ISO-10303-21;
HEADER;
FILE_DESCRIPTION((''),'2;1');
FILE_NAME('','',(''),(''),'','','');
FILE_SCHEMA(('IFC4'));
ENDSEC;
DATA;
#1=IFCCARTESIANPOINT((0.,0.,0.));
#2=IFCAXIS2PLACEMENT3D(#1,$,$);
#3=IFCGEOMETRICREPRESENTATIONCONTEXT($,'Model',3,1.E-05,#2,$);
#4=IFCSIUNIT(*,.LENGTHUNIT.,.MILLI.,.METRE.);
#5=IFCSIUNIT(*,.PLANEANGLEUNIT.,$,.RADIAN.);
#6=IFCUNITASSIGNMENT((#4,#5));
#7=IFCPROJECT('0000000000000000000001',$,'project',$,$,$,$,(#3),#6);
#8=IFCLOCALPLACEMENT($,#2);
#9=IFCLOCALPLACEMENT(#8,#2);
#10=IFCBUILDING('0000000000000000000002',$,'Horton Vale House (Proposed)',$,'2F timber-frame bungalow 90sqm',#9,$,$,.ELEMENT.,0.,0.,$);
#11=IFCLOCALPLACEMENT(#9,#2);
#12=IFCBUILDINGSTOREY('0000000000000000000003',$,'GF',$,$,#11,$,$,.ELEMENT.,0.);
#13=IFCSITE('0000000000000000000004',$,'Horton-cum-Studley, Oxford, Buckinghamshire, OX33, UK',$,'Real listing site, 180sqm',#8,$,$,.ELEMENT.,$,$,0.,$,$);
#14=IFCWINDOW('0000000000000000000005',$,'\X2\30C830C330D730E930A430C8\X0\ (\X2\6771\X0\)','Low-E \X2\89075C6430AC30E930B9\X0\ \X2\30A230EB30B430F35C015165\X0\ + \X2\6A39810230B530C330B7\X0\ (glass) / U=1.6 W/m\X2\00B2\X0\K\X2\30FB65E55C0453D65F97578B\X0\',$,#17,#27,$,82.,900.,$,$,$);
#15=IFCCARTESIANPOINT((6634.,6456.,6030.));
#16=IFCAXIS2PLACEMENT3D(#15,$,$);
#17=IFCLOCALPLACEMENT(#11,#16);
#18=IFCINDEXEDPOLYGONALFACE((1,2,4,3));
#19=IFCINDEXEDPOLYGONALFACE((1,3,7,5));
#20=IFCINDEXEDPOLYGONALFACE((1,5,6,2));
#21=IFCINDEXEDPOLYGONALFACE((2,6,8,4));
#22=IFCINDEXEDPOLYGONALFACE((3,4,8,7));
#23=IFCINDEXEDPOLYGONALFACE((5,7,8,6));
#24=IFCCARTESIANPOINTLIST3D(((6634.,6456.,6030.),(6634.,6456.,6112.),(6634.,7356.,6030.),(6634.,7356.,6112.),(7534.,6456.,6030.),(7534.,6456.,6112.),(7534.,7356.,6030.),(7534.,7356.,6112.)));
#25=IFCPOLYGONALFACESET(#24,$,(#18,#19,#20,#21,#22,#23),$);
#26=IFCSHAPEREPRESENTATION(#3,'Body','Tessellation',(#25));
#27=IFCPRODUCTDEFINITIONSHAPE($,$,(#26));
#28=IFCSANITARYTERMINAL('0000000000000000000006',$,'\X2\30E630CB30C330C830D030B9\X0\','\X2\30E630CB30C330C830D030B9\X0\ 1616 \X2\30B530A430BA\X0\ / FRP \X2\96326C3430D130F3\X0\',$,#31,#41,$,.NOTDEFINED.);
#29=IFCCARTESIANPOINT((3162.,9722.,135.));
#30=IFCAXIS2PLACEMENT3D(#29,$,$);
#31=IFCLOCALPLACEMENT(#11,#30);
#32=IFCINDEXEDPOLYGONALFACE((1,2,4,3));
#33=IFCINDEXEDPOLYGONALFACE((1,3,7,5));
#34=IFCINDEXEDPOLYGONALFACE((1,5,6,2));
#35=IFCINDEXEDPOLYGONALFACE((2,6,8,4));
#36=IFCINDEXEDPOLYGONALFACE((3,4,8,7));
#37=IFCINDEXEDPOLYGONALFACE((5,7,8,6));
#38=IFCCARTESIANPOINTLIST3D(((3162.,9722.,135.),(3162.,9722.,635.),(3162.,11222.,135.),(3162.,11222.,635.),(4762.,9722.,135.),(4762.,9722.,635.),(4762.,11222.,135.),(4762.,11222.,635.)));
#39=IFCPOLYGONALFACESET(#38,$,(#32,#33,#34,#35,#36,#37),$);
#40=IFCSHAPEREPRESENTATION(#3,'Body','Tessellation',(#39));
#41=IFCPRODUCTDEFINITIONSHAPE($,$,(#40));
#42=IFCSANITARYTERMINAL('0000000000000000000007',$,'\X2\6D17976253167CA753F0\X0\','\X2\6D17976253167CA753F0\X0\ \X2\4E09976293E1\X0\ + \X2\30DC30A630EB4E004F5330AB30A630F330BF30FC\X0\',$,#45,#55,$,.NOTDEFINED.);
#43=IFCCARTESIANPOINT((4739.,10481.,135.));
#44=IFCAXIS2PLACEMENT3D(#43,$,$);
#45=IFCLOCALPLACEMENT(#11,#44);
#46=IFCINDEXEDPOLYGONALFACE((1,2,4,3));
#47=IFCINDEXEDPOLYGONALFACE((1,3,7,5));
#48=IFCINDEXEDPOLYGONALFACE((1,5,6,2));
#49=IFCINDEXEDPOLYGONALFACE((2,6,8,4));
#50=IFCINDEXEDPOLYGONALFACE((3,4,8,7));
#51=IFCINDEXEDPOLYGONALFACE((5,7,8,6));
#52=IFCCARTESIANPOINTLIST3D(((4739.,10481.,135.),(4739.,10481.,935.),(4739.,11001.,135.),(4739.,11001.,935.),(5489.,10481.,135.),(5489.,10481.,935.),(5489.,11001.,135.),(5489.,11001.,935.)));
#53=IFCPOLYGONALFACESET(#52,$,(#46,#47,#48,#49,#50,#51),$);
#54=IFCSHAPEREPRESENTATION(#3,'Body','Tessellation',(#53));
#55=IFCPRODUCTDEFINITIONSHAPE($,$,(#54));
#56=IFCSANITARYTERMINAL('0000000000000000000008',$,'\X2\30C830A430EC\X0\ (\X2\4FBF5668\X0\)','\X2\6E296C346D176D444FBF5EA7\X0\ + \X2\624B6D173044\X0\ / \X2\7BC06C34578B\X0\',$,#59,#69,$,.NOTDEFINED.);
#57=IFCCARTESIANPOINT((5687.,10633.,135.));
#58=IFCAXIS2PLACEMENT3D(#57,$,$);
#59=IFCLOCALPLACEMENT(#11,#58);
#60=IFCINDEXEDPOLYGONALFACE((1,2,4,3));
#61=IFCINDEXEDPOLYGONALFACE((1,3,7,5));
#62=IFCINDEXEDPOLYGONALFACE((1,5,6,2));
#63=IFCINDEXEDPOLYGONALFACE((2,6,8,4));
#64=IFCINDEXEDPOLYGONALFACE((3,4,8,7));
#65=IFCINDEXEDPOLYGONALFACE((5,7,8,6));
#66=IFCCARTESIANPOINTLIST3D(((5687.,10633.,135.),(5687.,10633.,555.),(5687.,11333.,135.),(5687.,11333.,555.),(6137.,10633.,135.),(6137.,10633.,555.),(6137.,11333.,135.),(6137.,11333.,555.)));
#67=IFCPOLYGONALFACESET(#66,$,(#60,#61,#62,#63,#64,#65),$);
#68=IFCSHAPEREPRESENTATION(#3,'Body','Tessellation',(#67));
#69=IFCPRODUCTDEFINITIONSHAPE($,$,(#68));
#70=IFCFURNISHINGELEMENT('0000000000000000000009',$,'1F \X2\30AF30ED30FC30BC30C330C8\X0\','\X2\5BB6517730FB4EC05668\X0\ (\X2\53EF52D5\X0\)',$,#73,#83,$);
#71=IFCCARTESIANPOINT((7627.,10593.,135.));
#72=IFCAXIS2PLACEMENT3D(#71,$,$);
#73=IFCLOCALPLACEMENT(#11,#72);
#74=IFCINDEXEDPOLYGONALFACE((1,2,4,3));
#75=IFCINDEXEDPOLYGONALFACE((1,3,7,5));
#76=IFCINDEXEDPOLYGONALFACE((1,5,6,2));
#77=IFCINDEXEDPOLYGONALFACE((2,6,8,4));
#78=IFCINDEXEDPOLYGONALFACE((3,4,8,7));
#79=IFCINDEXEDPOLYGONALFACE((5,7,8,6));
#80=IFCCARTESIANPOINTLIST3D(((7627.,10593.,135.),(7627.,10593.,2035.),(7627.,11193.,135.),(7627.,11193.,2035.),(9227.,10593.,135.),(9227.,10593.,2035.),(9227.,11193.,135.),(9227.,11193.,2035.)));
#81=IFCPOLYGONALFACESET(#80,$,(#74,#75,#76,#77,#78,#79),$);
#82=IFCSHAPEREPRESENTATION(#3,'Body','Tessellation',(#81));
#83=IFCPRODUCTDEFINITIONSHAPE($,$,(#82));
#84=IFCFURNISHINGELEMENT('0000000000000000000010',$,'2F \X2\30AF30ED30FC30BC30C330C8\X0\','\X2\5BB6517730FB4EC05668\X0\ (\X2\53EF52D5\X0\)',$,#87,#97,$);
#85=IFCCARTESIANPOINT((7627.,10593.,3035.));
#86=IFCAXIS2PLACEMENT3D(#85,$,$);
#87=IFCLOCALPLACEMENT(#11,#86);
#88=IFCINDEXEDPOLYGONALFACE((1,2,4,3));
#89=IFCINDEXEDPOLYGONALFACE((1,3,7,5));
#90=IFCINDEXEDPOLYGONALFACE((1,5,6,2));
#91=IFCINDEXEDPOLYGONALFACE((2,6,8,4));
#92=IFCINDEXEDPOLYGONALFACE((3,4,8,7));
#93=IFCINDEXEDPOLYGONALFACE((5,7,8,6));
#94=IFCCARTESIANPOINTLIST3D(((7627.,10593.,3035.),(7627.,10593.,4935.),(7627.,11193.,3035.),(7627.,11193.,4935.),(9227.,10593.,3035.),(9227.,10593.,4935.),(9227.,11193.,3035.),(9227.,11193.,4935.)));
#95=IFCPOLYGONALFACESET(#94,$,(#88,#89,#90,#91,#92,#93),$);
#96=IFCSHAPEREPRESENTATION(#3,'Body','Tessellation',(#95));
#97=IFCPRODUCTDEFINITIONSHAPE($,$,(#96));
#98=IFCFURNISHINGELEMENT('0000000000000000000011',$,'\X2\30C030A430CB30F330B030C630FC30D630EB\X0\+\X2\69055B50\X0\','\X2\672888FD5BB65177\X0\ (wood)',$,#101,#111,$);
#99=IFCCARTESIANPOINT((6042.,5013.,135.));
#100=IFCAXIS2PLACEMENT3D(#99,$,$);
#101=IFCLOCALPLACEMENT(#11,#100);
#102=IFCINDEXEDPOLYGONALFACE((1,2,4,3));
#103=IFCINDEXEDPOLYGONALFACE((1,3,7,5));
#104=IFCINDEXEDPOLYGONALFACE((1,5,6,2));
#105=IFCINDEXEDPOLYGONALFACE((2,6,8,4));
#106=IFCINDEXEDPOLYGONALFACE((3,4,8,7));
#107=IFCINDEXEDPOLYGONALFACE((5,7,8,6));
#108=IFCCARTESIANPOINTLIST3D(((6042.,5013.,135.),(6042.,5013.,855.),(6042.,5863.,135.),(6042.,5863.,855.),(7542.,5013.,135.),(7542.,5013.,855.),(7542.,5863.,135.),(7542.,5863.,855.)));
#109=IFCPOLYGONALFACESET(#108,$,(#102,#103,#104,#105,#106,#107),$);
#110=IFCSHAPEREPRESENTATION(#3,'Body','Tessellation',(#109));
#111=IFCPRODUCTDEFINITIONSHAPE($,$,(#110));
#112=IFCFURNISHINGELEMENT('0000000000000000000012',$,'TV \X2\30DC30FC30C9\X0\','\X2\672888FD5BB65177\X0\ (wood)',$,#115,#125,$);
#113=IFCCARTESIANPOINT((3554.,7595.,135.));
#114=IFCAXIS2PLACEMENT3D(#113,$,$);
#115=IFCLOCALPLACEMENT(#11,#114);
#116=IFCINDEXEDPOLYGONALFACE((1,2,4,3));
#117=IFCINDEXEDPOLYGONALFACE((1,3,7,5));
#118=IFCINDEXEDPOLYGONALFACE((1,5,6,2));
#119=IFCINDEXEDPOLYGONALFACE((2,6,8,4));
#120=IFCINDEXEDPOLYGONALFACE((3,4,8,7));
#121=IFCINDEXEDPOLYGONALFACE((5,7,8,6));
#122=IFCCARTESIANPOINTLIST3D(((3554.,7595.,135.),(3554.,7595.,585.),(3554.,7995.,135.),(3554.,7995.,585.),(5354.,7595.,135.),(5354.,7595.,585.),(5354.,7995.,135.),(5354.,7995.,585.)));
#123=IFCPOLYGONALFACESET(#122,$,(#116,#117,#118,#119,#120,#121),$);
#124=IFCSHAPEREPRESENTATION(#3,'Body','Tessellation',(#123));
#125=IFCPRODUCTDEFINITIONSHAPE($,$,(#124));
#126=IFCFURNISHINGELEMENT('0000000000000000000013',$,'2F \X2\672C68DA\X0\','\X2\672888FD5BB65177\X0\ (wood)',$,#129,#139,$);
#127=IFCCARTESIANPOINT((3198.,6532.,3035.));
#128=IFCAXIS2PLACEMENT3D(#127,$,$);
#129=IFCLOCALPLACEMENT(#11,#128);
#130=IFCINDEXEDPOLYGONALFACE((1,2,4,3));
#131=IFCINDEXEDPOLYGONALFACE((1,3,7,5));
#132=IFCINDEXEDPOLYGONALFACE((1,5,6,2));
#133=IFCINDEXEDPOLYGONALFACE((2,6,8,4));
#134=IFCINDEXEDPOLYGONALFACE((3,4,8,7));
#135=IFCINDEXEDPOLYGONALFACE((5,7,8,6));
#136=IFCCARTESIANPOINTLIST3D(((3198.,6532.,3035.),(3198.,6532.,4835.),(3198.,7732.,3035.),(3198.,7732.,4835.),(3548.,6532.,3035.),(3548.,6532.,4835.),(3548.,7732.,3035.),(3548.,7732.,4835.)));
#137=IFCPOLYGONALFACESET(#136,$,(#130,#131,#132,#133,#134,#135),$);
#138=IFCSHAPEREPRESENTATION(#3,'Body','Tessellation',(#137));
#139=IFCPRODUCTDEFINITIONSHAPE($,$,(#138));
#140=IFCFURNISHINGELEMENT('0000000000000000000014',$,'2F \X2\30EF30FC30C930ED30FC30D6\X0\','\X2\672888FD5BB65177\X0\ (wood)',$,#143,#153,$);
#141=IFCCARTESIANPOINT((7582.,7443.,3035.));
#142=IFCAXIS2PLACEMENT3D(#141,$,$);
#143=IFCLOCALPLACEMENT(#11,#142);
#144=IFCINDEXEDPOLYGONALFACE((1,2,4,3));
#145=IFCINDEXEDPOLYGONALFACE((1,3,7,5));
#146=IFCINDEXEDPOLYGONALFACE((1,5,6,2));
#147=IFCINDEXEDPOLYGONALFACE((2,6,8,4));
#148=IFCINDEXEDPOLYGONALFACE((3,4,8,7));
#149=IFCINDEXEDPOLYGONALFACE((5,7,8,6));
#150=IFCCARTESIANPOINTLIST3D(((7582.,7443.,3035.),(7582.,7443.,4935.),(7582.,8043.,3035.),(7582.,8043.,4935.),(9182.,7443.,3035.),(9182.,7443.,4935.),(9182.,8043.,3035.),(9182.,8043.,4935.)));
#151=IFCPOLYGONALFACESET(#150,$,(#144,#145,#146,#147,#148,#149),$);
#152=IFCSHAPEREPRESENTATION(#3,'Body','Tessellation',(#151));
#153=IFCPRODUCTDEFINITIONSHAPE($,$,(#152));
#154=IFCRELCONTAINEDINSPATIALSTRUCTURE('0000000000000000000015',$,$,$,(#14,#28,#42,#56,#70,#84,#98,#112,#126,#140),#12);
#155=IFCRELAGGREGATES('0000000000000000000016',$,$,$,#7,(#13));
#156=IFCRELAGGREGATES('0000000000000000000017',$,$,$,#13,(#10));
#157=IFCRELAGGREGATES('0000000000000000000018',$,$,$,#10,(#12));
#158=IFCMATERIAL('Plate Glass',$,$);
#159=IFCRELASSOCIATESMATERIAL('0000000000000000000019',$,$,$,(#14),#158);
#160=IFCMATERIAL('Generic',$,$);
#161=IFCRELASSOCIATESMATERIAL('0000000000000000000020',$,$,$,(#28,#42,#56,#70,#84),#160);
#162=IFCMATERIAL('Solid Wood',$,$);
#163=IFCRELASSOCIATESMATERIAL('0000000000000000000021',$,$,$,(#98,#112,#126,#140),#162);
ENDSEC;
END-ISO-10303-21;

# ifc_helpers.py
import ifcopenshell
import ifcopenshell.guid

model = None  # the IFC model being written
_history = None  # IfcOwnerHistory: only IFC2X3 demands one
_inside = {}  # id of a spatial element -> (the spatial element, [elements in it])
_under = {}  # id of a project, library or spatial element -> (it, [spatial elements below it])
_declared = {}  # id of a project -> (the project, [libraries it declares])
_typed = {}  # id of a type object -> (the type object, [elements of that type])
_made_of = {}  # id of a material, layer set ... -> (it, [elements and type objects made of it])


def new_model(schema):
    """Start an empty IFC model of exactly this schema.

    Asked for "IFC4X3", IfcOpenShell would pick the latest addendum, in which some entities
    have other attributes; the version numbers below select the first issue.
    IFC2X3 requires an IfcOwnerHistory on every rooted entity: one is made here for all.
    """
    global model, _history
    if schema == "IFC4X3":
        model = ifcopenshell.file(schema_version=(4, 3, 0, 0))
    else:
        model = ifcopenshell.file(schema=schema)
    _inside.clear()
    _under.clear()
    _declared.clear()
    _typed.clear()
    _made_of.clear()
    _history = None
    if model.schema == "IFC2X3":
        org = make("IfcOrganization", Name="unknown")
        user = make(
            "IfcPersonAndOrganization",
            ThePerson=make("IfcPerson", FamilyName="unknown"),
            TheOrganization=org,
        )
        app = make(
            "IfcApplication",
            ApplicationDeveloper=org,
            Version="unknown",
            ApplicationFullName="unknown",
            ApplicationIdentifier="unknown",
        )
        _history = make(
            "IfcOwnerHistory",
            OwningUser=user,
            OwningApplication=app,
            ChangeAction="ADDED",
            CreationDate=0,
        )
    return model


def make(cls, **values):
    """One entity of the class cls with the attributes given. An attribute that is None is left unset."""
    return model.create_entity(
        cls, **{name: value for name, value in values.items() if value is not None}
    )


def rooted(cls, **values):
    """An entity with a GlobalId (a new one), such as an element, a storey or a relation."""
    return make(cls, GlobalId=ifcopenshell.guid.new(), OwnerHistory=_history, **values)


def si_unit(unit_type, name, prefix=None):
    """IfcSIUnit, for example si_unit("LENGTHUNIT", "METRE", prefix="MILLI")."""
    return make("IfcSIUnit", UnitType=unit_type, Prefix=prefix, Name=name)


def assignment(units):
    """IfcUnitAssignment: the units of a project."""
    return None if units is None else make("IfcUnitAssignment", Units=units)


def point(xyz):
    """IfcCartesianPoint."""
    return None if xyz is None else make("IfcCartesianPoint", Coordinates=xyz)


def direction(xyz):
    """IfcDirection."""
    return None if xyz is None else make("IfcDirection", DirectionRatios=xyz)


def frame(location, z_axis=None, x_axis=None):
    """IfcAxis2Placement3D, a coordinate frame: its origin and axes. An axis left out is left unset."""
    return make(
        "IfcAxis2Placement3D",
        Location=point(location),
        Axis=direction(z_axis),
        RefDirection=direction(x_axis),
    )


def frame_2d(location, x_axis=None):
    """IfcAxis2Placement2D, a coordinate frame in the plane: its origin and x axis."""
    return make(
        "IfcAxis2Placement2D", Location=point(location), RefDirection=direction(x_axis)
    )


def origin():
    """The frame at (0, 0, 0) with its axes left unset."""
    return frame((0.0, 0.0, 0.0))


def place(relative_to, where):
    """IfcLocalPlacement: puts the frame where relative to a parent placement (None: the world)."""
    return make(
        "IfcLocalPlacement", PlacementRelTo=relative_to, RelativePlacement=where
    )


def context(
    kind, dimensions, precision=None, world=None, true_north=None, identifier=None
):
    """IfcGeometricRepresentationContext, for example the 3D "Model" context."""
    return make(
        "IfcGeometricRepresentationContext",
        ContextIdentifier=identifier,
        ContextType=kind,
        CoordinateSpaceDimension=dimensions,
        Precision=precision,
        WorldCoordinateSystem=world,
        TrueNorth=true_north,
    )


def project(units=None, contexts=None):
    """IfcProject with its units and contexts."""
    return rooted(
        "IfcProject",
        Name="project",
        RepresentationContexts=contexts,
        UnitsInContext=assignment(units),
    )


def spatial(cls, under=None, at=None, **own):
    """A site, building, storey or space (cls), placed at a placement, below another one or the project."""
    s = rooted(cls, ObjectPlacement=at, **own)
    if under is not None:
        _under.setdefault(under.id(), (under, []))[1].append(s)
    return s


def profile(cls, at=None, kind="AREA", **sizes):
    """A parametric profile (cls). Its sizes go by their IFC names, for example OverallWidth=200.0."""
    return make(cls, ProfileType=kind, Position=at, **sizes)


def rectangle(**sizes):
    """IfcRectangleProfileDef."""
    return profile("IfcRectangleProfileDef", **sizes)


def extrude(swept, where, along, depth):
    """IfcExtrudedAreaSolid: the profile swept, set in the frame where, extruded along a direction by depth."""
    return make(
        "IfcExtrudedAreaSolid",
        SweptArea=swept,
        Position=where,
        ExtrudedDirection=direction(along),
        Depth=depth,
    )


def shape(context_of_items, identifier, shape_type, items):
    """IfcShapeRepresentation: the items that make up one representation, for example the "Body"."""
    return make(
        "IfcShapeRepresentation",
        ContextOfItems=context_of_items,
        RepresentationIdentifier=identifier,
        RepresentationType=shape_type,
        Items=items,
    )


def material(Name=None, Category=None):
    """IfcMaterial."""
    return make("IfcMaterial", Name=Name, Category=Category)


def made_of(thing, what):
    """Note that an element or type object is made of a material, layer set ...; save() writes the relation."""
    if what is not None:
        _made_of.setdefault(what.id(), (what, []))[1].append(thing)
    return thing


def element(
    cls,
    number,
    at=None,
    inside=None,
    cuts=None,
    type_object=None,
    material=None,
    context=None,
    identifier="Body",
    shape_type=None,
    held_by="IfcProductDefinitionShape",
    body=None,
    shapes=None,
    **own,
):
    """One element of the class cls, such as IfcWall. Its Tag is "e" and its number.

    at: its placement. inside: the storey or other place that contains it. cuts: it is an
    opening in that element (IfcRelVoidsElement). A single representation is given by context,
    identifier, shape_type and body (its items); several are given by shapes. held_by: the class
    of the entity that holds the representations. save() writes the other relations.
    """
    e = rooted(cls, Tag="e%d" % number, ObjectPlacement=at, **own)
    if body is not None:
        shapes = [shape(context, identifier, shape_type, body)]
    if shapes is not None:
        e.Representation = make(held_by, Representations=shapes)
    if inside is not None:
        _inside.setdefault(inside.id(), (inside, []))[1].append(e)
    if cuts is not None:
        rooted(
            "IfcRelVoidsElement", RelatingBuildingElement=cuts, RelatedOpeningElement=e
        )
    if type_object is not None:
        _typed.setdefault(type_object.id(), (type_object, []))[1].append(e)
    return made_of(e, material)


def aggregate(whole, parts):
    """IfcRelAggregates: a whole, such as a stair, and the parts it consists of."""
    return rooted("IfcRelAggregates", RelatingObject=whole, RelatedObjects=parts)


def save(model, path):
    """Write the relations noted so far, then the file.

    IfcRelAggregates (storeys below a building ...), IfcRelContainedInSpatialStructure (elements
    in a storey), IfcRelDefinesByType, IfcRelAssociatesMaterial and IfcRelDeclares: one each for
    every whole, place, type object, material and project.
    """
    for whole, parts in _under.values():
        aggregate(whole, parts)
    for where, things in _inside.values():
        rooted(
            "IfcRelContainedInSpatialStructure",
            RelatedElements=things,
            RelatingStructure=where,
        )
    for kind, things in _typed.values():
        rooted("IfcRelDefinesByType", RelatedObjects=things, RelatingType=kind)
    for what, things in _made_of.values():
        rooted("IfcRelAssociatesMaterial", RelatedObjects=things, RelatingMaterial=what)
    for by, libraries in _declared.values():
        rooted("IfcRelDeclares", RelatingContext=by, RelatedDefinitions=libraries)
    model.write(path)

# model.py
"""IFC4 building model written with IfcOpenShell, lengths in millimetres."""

from ifc_helpers import new_model, si_unit, frame, frame_2d, origin, place, context, project, spatial, rectangle, extrude, material, element, save


model = new_model("IFC4")

# Units and contexts
model_context = context("Model", 3, precision=1e-05, world=origin())
ifc_project = project(units=[si_unit("LENGTHUNIT", "METRE", prefix="MILLI"), si_unit("PLANEANGLEUNIT", "RADIAN")], contexts=[model_context])

# Site, building, storey
site_placement = place(None, origin())
site = spatial("IfcSite", under=ifc_project, at=site_placement, Name="Horton-cum-Studley, Oxford, Buckinghamshire, OX33, UK", ObjectType="Real listing site, 180sqm", CompositionType="ELEMENT", RefElevation=0.0)
building_placement = place(site_placement, origin())
building = spatial("IfcBuilding", under=site, at=building_placement, Name="Horton Vale House (Proposed)", ObjectType="2F timber-frame bungalow 90sqm", CompositionType="ELEMENT", ElevationOfRefHeight=0.0, ElevationOfTerrain=0.0)
storey_placement = place(building_placement, origin())
storey = spatial("IfcBuildingStorey", under=building, at=storey_placement, Name="GF", CompositionType="ELEMENT", Elevation=0.0)

# Shared definitions
ifc_material_1 = material(Name="Solid Wood")
ifc_material_2 = material(Name="Plate Glass")

# Window
window_1_placement = place(storey_placement, frame((6634.0, 6456.0, 6030.0)))
element("IfcWindow", 1, at=window_1_placement, inside=storey, material=ifc_material_2, Name="トップライト (東)", Description="Low-E 複層ガラス アルゴン封入 + 樹脂サッシ (glass) / U=1.6 W/m²K・日射取得型", OverallHeight=82.0, OverallWidth=900.0, context=model_context, shape_type="SweptSolid", body=[
    extrude(rectangle(XDim=900.0, YDim=900.0, at=frame_2d((450.0, 450.0))), frame((6634.0, 6456.0, 6030.0)), (0.0, 0.0, 1.0), 82.0),
])

# Sanitary terminals
ifc_material_3 = material(Name="Generic")
sanitary_terminal_1_placement = place(storey_placement, frame((3162.0, 9722.0, 135.0)))
element("IfcSanitaryTerminal", 2, at=sanitary_terminal_1_placement, inside=storey, material=ifc_material_3, Name="ユニットバス", Description="ユニットバス 1616 サイズ / FRP 防水パン", PredefinedType="NOTDEFINED", context=model_context, shape_type="SweptSolid", body=[
    extrude(rectangle(XDim=1600.0, YDim=1500.0, at=frame_2d((800.0, 750.0))), frame((3162.0, 9722.0, 135.0)), (0.0, 0.0, 1.0), 500.0),
])
sanitary_terminal_2_placement = place(storey_placement, frame((4739.0, 10481.0, 135.0)))
element("IfcSanitaryTerminal", 3, at=sanitary_terminal_2_placement, inside=storey, material=ifc_material_3, Name="洗面化粧台", Description="洗面化粧台 三面鏡 + ボウル一体カウンター", PredefinedType="NOTDEFINED", context=model_context, shape_type="SweptSolid", body=[
    extrude(rectangle(XDim=750.0, YDim=520.0, at=frame_2d((375.0, 260.0))), frame((4739.0, 10481.0, 135.0)), (0.0, 0.0, 1.0), 800.0),
])
sanitary_terminal_3_placement = place(storey_placement, frame((5687.0, 10633.0, 135.0)))
element("IfcSanitaryTerminal", 4, at=sanitary_terminal_3_placement, inside=storey, material=ifc_material_3, Name="トイレ (便器)", Description="温水洗浄便座 + 手洗い / 節水型", PredefinedType="NOTDEFINED", context=model_context, shape_type="SweptSolid", body=[
    extrude(rectangle(XDim=450.0, YDim=700.0, at=frame_2d((225.0, 350.0))), frame((5687.0, 10633.0, 135.0)), (0.0, 0.0, 1.0), 420.0),
])

# Furnishing elements
furnishing_1_placement = place(storey_placement, frame((7627.0, 10593.0, 135.0)))
element("IfcFurnishingElement", 5, at=furnishing_1_placement, inside=storey, material=ifc_material_3, Name="1F クローゼット", Description="家具・什器 (可動)", context=model_context, shape_type="SweptSolid", body=[
    extrude(rectangle(XDim=1600.0, YDim=600.0, at=frame_2d((800.0, 300.0))), frame((7627.0, 10593.0, 135.0)), (0.0, 0.0, 1.0), 1900.0),
])
furnishing_2_placement = place(storey_placement, frame((7627.0, 10593.0, 3035.0)))
element("IfcFurnishingElement", 6, at=furnishing_2_placement, inside=storey, material=ifc_material_3, Name="2F クローゼット", Description="家具・什器 (可動)", context=model_context, shape_type="SweptSolid", body=[
    extrude(rectangle(XDim=1600.0, YDim=600.0, at=frame_2d((800.0, 300.0))), frame((7627.0, 10593.0, 3035.0)), (0.0, 0.0, 1.0), 1900.0),
])
furnishing_3_placement = place(storey_placement, frame((6042.0, 5013.0, 135.0)))
element("IfcFurnishingElement", 7, at=furnishing_3_placement, inside=storey, material=ifc_material_1, Name="ダイニングテーブル+椅子", Description="木製家具 (wood)", context=model_context, shape_type="SweptSolid", body=[
    extrude(rectangle(XDim=1500.0, YDim=850.0, at=frame_2d((750.0, 425.0))), frame((6042.0, 5013.0, 135.0)), (0.0, 0.0, 1.0), 720.0),
])
furnishing_4_placement = place(storey_placement, frame((3554.0, 7595.0, 135.0)))
element("IfcFurnishingElement", 8, at=furnishing_4_placement, inside=storey, material=ifc_material_1, Name="TV ボード", Description="木製家具 (wood)", context=model_context, shape_type="SweptSolid", body=[
    extrude(rectangle(XDim=1800.0, YDim=400.0, at=frame_2d((900.0, 200.0))), frame((3554.0, 7595.0, 135.0)), (0.0, 0.0, 1.0), 450.0),
])
furnishing_5_placement = place(storey_placement, frame((3198.0, 6532.0, 3035.0)))
element("IfcFurnishingElement", 9, at=furnishing_5_placement, inside=storey, material=ifc_material_1, Name="2F 本棚", Description="木製家具 (wood)", context=model_context, shape_type="SweptSolid", body=[
    extrude(rectangle(XDim=350.0, YDim=1200.0, at=frame_2d((175.0, 600.0))), frame((3198.0, 6532.0, 3035.0)), (0.0, 0.0, 1.0), 1800.0),
])
furnishing_6_placement = place(storey_placement, frame((7582.0, 7443.0, 3035.0)))
element("IfcFurnishingElement", 10, at=furnishing_6_placement, inside=storey, material=ifc_material_1, Name="2F ワードローブ", Description="木製家具 (wood)", context=model_context, shape_type="SweptSolid", body=[
    extrude(rectangle(XDim=1600.0, YDim=600.0, at=frame_2d((800.0, 300.0))), frame((7582.0, 7443.0, 3035.0)), (0.0, 0.0, 1.0), 1900.0),
])

save(model, "model.ifc")
